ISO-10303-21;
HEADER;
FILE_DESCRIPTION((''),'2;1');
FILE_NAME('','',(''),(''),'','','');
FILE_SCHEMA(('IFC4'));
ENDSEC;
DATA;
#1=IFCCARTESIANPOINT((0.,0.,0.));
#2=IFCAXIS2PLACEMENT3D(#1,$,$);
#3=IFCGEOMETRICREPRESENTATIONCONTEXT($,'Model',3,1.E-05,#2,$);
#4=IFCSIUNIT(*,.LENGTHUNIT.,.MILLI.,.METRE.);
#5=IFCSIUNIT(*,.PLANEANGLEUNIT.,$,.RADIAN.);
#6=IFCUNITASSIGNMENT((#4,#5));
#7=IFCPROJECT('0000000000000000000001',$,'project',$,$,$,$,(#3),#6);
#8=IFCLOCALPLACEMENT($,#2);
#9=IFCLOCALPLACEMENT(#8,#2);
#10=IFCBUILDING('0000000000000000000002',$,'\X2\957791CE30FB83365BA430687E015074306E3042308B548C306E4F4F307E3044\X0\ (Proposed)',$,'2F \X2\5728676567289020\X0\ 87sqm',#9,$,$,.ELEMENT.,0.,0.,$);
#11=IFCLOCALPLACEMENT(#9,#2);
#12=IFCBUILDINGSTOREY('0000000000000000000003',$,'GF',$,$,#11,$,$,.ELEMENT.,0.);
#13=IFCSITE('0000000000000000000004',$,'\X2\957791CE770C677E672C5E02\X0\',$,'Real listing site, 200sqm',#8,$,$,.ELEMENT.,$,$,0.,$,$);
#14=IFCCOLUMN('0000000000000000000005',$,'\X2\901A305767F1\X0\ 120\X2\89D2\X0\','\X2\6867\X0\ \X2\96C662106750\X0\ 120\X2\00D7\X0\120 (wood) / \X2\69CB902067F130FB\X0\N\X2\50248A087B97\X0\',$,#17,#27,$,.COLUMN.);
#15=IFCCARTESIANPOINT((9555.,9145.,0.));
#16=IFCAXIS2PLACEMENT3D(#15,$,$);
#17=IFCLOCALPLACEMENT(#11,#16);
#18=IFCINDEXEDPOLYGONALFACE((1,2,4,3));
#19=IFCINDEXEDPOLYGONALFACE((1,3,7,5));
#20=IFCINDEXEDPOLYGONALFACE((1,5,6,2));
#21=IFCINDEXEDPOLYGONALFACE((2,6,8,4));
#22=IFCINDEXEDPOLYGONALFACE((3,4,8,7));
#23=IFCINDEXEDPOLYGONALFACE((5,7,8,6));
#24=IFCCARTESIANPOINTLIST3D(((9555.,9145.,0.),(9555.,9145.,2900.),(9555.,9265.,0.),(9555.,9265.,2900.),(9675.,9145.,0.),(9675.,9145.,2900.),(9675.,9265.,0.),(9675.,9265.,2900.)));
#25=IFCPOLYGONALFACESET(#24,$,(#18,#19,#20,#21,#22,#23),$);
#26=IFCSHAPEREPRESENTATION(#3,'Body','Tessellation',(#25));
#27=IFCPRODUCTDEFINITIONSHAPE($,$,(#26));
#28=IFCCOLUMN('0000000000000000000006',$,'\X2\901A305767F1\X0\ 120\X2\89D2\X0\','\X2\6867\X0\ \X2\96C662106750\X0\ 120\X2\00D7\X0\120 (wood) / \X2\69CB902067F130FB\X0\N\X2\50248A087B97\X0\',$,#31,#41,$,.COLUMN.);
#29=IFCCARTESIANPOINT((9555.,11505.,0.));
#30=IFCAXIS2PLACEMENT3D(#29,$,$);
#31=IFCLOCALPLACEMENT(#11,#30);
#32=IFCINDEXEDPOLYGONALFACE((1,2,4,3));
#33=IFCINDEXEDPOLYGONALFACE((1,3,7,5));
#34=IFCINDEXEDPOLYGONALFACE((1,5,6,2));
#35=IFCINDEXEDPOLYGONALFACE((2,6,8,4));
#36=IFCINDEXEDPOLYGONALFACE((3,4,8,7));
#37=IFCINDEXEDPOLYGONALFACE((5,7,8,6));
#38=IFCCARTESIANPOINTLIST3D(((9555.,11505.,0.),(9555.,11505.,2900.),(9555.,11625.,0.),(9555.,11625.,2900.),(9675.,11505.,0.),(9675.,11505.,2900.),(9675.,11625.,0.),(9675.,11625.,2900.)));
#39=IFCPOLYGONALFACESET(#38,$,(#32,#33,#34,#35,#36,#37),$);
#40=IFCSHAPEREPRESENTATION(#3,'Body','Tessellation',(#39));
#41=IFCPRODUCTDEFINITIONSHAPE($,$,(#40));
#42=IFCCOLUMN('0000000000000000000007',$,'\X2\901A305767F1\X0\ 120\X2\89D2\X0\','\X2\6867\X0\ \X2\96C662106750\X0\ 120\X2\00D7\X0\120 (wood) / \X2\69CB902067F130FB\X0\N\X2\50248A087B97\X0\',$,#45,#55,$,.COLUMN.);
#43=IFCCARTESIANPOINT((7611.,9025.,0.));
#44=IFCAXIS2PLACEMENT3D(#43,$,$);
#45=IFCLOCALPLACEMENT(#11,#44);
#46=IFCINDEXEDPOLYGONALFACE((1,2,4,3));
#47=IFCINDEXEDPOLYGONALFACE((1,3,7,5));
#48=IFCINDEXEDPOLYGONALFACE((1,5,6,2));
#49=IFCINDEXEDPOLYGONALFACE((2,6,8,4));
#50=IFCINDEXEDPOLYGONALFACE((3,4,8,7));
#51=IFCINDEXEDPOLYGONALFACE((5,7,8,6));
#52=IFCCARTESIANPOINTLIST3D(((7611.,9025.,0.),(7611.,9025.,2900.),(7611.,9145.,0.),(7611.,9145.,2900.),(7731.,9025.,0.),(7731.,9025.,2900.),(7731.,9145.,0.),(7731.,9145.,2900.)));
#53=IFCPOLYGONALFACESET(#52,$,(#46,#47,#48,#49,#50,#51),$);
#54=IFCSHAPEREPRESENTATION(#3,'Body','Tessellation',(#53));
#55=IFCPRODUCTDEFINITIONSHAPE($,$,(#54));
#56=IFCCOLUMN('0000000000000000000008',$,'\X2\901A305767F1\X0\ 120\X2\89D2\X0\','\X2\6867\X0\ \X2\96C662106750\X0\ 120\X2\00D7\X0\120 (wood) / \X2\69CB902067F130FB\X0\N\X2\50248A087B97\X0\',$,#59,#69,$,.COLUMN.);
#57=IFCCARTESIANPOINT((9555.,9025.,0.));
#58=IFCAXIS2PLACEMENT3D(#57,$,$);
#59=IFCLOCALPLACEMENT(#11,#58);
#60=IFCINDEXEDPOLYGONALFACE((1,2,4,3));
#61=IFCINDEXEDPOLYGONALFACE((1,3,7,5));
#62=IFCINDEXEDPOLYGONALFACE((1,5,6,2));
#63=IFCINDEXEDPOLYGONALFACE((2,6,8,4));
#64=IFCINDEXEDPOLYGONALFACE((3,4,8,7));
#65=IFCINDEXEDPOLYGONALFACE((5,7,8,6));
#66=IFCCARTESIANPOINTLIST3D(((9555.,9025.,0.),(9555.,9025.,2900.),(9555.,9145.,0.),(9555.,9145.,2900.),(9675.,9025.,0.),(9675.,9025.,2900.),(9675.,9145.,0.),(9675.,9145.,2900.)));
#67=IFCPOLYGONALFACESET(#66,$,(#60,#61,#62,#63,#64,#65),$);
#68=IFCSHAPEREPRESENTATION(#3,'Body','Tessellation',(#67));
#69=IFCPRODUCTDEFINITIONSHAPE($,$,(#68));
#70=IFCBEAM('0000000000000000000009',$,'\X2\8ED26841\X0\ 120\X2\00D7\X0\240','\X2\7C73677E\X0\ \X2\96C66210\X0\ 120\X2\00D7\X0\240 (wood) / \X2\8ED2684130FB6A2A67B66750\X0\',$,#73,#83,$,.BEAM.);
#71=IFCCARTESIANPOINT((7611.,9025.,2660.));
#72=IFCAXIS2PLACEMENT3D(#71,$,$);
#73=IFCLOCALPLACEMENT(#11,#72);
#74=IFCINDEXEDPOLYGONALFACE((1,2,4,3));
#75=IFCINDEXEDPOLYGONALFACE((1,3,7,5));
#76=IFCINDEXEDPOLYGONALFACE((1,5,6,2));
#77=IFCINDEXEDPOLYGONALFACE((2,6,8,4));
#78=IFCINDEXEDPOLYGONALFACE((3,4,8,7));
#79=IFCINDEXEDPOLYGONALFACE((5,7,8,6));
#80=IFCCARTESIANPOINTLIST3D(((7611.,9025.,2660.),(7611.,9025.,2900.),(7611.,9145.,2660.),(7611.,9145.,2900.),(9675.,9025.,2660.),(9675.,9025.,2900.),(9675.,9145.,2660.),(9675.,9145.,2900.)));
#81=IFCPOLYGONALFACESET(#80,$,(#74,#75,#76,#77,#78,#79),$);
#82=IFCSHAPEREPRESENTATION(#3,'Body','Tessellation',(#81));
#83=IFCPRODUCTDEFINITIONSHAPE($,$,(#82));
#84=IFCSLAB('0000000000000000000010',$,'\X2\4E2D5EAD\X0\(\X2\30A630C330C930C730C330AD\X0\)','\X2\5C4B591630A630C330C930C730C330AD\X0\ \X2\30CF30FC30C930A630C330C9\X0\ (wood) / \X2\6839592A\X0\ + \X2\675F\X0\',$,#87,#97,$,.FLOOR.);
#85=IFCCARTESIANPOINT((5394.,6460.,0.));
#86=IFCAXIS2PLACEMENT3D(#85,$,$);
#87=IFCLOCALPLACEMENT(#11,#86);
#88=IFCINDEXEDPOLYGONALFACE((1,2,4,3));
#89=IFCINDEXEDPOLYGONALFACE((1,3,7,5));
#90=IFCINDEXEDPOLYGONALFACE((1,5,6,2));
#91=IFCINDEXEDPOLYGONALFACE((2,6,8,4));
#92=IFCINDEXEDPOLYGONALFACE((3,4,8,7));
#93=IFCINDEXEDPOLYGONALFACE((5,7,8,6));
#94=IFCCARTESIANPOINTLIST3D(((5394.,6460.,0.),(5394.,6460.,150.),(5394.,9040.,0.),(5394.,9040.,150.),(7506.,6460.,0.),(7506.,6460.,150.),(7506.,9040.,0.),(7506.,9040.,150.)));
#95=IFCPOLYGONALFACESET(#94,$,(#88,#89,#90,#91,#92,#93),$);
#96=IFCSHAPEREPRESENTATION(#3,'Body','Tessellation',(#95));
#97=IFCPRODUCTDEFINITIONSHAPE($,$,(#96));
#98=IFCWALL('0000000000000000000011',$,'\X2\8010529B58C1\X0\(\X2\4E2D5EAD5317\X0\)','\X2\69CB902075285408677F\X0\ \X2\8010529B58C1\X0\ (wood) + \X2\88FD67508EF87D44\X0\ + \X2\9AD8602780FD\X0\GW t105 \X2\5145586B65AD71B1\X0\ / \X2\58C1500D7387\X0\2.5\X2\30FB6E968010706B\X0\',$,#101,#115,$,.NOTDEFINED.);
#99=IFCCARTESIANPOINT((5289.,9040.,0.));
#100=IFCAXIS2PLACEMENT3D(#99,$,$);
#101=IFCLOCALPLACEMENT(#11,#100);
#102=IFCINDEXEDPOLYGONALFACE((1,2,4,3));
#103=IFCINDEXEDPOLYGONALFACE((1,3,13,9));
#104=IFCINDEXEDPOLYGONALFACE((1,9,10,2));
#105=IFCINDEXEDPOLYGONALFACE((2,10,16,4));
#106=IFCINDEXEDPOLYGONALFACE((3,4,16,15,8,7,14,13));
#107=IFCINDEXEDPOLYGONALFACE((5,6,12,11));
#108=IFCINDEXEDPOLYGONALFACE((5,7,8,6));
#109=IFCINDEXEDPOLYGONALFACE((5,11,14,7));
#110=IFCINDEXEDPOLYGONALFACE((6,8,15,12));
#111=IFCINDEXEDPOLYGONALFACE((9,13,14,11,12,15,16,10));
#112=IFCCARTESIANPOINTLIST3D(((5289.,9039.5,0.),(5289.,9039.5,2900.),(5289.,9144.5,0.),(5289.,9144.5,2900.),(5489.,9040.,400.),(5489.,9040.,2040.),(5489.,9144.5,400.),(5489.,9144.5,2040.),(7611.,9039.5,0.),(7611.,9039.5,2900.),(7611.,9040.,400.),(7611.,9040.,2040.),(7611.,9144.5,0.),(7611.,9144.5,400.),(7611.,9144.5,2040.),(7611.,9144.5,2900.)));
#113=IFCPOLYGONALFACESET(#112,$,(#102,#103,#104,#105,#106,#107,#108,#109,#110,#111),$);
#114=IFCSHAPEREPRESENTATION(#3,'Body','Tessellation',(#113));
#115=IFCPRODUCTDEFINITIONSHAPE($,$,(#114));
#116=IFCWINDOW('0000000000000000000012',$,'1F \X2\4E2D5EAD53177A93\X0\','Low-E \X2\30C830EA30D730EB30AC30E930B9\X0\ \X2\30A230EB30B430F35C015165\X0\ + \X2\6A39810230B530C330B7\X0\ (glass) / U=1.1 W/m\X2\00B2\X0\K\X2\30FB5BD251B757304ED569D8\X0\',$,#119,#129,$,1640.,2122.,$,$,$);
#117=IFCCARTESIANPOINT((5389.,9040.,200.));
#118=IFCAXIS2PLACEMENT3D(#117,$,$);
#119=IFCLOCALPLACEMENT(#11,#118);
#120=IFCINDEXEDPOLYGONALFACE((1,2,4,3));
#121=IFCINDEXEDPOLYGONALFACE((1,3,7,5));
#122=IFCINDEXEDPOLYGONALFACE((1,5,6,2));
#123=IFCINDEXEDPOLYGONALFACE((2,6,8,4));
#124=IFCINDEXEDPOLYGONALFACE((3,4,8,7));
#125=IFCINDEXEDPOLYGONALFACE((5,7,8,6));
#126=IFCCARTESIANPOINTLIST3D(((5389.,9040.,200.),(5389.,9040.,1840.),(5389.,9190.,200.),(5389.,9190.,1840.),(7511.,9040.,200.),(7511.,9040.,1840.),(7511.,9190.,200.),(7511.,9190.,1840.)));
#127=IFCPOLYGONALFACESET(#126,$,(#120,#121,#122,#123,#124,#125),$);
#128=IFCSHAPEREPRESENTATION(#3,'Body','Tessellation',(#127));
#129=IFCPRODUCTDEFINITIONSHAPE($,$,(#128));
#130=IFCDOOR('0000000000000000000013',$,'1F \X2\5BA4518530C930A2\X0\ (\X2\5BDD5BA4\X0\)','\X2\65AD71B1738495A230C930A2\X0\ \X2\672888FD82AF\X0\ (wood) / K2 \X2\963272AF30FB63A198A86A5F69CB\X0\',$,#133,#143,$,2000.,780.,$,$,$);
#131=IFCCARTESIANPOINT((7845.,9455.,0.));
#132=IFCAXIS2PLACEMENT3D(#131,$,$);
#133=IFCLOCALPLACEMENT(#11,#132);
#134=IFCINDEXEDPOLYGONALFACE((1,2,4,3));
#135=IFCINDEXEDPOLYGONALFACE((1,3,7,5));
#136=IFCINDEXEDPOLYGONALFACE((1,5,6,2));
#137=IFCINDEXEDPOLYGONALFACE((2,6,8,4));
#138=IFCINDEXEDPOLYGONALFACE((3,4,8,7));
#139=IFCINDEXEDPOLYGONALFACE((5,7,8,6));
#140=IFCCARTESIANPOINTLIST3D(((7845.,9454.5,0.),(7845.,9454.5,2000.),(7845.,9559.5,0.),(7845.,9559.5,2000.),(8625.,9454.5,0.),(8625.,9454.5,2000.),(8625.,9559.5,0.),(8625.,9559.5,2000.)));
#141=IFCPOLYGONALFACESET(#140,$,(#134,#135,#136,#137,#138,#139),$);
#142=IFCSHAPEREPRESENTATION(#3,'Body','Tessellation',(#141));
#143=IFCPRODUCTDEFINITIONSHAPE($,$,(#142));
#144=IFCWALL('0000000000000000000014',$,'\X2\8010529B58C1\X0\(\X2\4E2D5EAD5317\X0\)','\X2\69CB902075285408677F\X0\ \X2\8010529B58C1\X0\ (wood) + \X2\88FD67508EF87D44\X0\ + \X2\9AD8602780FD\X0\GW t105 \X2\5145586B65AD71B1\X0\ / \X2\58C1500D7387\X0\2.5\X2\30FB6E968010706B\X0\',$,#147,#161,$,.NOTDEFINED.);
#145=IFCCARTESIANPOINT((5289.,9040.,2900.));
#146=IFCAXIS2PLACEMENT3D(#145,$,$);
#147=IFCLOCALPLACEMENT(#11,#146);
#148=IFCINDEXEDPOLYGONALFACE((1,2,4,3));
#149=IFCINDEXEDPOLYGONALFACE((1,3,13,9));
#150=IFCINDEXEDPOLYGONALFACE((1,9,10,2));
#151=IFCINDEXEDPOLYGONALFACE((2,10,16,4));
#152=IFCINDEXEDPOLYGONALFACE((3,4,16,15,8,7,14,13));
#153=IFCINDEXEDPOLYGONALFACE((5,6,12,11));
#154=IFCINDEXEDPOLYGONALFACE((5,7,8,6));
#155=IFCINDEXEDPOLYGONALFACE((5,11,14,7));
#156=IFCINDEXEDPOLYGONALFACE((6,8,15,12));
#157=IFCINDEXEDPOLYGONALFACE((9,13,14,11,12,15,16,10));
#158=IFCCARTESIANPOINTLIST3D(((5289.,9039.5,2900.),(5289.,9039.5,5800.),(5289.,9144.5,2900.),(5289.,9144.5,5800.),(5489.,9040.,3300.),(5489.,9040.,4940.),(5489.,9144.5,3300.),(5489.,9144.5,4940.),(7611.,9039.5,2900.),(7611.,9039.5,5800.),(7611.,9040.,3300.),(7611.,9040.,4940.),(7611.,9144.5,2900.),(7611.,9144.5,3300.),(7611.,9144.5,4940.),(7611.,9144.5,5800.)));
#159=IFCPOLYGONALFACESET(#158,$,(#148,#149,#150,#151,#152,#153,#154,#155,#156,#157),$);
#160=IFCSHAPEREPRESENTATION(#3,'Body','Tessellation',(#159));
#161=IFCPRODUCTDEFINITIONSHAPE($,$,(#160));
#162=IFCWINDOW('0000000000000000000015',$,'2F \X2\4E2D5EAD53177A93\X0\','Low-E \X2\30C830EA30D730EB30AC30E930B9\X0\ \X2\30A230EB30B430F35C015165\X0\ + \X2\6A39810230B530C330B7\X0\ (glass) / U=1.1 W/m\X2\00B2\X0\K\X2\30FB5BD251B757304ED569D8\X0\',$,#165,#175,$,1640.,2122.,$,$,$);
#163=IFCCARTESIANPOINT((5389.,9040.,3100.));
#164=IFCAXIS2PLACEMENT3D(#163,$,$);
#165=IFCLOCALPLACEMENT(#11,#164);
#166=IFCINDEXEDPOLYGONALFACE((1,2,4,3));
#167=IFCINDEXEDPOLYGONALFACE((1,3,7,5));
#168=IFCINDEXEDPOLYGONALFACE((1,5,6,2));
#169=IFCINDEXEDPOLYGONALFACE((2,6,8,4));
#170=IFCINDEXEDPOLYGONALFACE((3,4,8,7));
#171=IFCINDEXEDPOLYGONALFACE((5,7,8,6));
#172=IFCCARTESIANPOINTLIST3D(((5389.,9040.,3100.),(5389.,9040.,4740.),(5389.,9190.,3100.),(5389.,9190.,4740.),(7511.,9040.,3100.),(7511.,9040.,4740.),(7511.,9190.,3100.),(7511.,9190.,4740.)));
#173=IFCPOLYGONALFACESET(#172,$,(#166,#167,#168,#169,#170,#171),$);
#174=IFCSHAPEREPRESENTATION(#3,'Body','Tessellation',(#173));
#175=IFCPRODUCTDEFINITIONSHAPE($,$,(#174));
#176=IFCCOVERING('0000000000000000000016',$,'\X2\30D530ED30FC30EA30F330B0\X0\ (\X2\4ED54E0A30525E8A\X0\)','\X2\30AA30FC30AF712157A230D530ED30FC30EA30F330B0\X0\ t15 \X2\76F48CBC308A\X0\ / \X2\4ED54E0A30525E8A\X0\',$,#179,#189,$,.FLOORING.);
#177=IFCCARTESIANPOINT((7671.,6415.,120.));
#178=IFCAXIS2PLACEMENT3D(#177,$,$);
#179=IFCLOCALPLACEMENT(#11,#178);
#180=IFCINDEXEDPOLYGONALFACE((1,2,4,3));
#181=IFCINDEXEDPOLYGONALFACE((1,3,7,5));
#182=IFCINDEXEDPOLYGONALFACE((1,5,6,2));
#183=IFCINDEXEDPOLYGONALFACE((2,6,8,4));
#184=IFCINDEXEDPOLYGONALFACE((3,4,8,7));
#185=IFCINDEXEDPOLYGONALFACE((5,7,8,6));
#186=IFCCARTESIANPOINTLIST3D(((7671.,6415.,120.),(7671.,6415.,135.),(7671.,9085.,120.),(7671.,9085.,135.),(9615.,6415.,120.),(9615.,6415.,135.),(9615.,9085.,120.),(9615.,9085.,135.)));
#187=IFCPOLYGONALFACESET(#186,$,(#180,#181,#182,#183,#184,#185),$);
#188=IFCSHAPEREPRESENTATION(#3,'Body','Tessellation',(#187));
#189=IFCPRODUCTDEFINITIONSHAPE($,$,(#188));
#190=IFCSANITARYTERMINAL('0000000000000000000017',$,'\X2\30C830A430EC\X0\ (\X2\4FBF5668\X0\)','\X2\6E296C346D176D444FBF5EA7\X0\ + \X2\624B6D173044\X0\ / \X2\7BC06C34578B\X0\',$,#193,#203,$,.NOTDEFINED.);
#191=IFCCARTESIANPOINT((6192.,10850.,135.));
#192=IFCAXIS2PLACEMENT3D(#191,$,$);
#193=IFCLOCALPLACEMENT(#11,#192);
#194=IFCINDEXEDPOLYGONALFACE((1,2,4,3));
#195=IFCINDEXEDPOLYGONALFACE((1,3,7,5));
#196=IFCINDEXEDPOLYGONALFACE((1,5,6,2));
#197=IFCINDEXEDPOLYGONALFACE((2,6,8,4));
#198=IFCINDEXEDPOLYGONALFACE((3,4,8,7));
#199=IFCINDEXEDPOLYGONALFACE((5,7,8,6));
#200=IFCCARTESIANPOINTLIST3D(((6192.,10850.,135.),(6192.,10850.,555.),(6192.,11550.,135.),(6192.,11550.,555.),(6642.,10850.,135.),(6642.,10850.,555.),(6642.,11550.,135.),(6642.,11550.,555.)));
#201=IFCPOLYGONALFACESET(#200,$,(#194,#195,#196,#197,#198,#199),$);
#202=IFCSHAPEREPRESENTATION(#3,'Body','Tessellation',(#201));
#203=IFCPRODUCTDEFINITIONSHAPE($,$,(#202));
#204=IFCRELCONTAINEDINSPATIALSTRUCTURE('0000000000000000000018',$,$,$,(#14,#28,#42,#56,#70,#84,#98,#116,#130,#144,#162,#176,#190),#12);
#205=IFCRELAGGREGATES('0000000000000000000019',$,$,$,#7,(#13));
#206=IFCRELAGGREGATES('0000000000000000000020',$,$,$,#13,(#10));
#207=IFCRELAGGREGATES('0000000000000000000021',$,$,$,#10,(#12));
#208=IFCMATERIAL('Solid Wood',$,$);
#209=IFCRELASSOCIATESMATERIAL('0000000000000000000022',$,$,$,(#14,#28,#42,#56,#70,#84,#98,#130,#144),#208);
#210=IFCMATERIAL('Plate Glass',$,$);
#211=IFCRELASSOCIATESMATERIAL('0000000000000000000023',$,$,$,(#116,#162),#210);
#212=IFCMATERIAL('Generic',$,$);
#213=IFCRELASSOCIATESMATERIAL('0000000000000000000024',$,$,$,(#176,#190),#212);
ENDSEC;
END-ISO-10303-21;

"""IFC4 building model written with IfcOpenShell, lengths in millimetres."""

from ifc_helpers import new_model, si_unit, frame, frame_2d, origin, place, context, project, spatial, rectangle, extrude, material, element, fill, save


model = new_model("IFC4")

# Units and contexts
model_context = context("Model", 3, precision=1e-05, world=origin())
ifc_project = project(units=[si_unit("LENGTHUNIT", "METRE", prefix="MILLI"), si_unit("PLANEANGLEUNIT", "RADIAN")], contexts=[model_context])

# Site, building, storey
site_placement = place(None, origin())
site = spatial("IfcSite", under=ifc_project, at=site_placement, Name="長野県松本市", ObjectType="Real listing site, 200sqm", CompositionType="ELEMENT", RefElevation=0.0)
building_placement = place(site_placement, origin())
building = spatial("IfcBuilding", under=site, at=building_placement, Name="長野・茶室と縁側のある和の住まい (Proposed)", ObjectType="2F 在来木造 87sqm", CompositionType="ELEMENT", ElevationOfRefHeight=0.0, ElevationOfTerrain=0.0)
storey_placement = place(building_placement, origin())
storey = spatial("IfcBuildingStorey", under=building, at=storey_placement, Name="GF", CompositionType="ELEMENT", Elevation=0.0)

# Columns
ifc_material_1 = material(Name="Solid Wood")
column_1_placement = place(storey_placement, frame((9555.0, 9145.0, 0.0)))
element("IfcColumn", 1, at=column_1_placement, inside=storey, material=ifc_material_1, Name="通し柱 120角", Description="桧 集成材 120×120 (wood) / 構造柱・N値計算", PredefinedType="COLUMN", context=model_context, shape_type="SweptSolid", body=[
    extrude(rectangle(XDim=120.0, YDim=120.0, at=frame_2d((60.0, 60.0))), frame((9555.0, 9145.0, 0.0)), (0.0, 0.0, 1.0), 2900.0),
])
column_2_placement = place(storey_placement, frame((9555.0, 11505.0, 0.0)))
element("IfcColumn", 2, at=column_2_placement, inside=storey, material=ifc_material_1, Name="通し柱 120角", Description="桧 集成材 120×120 (wood) / 構造柱・N値計算", PredefinedType="COLUMN", context=model_context, shape_type="SweptSolid", body=[
    extrude(rectangle(XDim=120.0, YDim=120.0, at=frame_2d((60.0, 60.0))), frame((9555.0, 11505.0, 0.0)), (0.0, 0.0, 1.0), 2900.0),
])
column_3_placement = place(storey_placement, frame((7611.0, 9025.0, 0.0)))
element("IfcColumn", 3, at=column_3_placement, inside=storey, material=ifc_material_1, Name="通し柱 120角", Description="桧 集成材 120×120 (wood) / 構造柱・N値計算", PredefinedType="COLUMN", context=model_context, shape_type="SweptSolid", body=[
    extrude(rectangle(XDim=120.0, YDim=120.0, at=frame_2d((60.0, 60.0))), frame((7611.0, 9025.0, 0.0)), (0.0, 0.0, 1.0), 2900.0),
])
column_4_placement = place(storey_placement, frame((9555.0, 9025.0, 0.0)))
element("IfcColumn", 4, at=column_4_placement, inside=storey, material=ifc_material_1, Name="通し柱 120角", Description="桧 集成材 120×120 (wood) / 構造柱・N値計算", PredefinedType="COLUMN", context=model_context, shape_type="SweptSolid", body=[
    extrude(rectangle(XDim=120.0, YDim=120.0, at=frame_2d((60.0, 60.0))), frame((9555.0, 9025.0, 0.0)), (0.0, 0.0, 1.0), 2900.0),
])

# Beam
beam_1_placement = place(storey_placement, frame((7611.0, 9025.0, 2660.0)))
element("IfcBeam", 5, at=beam_1_placement, inside=storey, material=ifc_material_1, Name="軒桁 120×240", Description="米松 集成 120×240 (wood) / 軒桁・横架材", PredefinedType="BEAM", context=model_context, shape_type="SweptSolid", body=[
    extrude(rectangle(XDim=2064.0, YDim=120.0, at=frame_2d((1032.0, 60.0))), frame((7611.0, 9025.0, 2660.0)), (0.0, 0.0, 1.0), 240.0),
])

# Slab
slab_placement = place(storey_placement, frame((5394.0, 6460.0, 0.0)))
element("IfcSlab", 6, at=slab_placement, inside=storey, material=ifc_material_1, Name="中庭(ウッドデッキ)", Description="屋外ウッドデッキ ハードウッド (wood) / 根太 + 束", PredefinedType="FLOOR", context=model_context, shape_type="SweptSolid", body=[
    extrude(rectangle(XDim=2112.0, YDim=2580.0, at=frame_2d((1056.0, 1290.0))), frame((5394.0, 6460.0, 0.0)), (0.0, 0.0, 1.0), 150.0),
])

# Wall, opening, window
wall_1_placement = place(storey_placement, frame((5289.0, 9040.0, 0.0)))
wall_1 = element("IfcWall", 7, at=wall_1_placement, inside=storey, material=ifc_material_1, Name="耐力壁(中庭北)", Description="構造用合板 耐力壁 (wood) + 製材軸組 + 高性能GW t105 充填断熱 / 壁倍率2.5・準耐火", PredefinedType="NOTDEFINED", context=model_context, shape_type="SweptSolid", body=[
    extrude(rectangle(XDim=2322.0, YDim=105.0, at=frame_2d((1161.0, 52.0))), frame((5289.0, 9040.0, 0.0)), (0.0, 0.0, 1.0), 2900.0),
])
opening_1_placement = place(storey_placement, frame((5389.0, 9040.0, 200.0)))
opening_1 = element("IfcOpeningElement", 8, at=opening_1_placement, cuts=wall_1, PredefinedType="NOTDEFINED", context=model_context, shape_type="SweptSolid", body=[
    extrude(rectangle(XDim=2122.0, YDim=150.0, at=frame_2d((1061.0, 75.0))), frame((5389.0, 9040.0, 200.0)), (0.0, 0.0, 1.0), 1640.0),
])
ifc_material_2 = material(Name="Plate Glass")
window_1_placement = place(storey_placement, frame((5389.0, 9040.0, 200.0)))
window_1 = element("IfcWindow", 9, at=window_1_placement, inside=storey, material=ifc_material_2, Name="1F 中庭北窓", Description="Low-E トリプルガラス アルゴン封入 + 樹脂サッシ (glass) / U=1.1 W/m²K・寒冷地仕様", OverallHeight=1640.0, OverallWidth=2122.0, context=model_context, shape_type="SweptSolid", body=[
    extrude(rectangle(XDim=2122.0, YDim=150.0, at=frame_2d((1061.0, 75.0))), frame((5389.0, 9040.0, 200.0)), (0.0, 0.0, 1.0), 1640.0),
])
fill(opening_1, window_1)

# Door
door_placement = place(storey_placement, frame((7845.0, 9455.0, 0.0)))
element("IfcDoor", 10, at=door_placement, inside=storey, material=ifc_material_1, Name="1F 室内ドア (寝室)", Description="断熱玄関ドア 木製芯 (wood) / K2 防犯・採風機構", OverallHeight=2000.0, OverallWidth=780.0, context=model_context, shape_type="SweptSolid", body=[
    extrude(rectangle(XDim=780.0, YDim=105.0, at=frame_2d((390.0, 52.0))), frame((7845.0, 9455.0, 0.0)), (0.0, 0.0, 1.0), 2000.0),
])

# Wall, opening, window
wall_2_placement = place(storey_placement, frame((5289.0, 9040.0, 2900.0)))
wall_2 = element("IfcWall", 11, at=wall_2_placement, inside=storey, material=ifc_material_1, Name="耐力壁(中庭北)", Description="構造用合板 耐力壁 (wood) + 製材軸組 + 高性能GW t105 充填断熱 / 壁倍率2.5・準耐火", PredefinedType="NOTDEFINED", context=model_context, shape_type="SweptSolid", body=[
    extrude(rectangle(XDim=2322.0, YDim=105.0, at=frame_2d((1161.0, 52.0))), frame((5289.0, 9040.0, 2900.0)), (0.0, 0.0, 1.0), 2900.0),
])
opening_2_placement = place(storey_placement, frame((5389.0, 9040.0, 3100.0)))
opening_2 = element("IfcOpeningElement", 12, at=opening_2_placement, cuts=wall_2, PredefinedType="NOTDEFINED", context=model_context, shape_type="SweptSolid", body=[
    extrude(rectangle(XDim=2122.0, YDim=150.0, at=frame_2d((1061.0, 75.0))), frame((5389.0, 9040.0, 3100.0)), (0.0, 0.0, 1.0), 1640.0),
])
window_2_placement = place(storey_placement, frame((5389.0, 9040.0, 3100.0)))
window_2 = element("IfcWindow", 13, at=window_2_placement, inside=storey, material=ifc_material_2, Name="2F 中庭北窓", Description="Low-E トリプルガラス アルゴン封入 + 樹脂サッシ (glass) / U=1.1 W/m²K・寒冷地仕様", OverallHeight=1640.0, OverallWidth=2122.0, context=model_context, shape_type="SweptSolid", body=[
    extrude(rectangle(XDim=2122.0, YDim=150.0, at=frame_2d((1061.0, 75.0))), frame((5389.0, 9040.0, 3100.0)), (0.0, 0.0, 1.0), 1640.0),
])
fill(opening_2, window_2)

# Covering
ifc_material_3 = material(Name="Generic")
covering_placement = place(storey_placement, frame((7671.0, 6415.0, 120.0)))
element("IfcCovering", 14, at=covering_placement, inside=storey, material=ifc_material_3, Name="フローリング (仕上げ床)", Description="オーク無垢フローリング t15 直貼り / 仕上げ床", PredefinedType="FLOORING", context=model_context, shape_type="SweptSolid", body=[
    extrude(rectangle(XDim=1944.0, YDim=2670.0, at=frame_2d((972.0, 1335.0))), frame((7671.0, 6415.0, 120.0)), (0.0, 0.0, 1.0), 15.0),
])

# Sanitary terminal
sanitary_terminal_placement = place(storey_placement, frame((6192.0, 10850.0, 135.0)))
element("IfcSanitaryTerminal", 15, at=sanitary_terminal_placement, inside=storey, material=ifc_material_3, Name="トイレ (便器)", Description="温水洗浄便座 + 手洗い / 節水型", PredefinedType="NOTDEFINED", context=model_context, shape_type="SweptSolid", body=[
    extrude(rectangle(XDim=450.0, YDim=700.0, at=frame_2d((225.0, 350.0))), frame((6192.0, 10850.0, 135.0)), (0.0, 0.0, 1.0), 420.0),
])

save(model, "model.ifc")
